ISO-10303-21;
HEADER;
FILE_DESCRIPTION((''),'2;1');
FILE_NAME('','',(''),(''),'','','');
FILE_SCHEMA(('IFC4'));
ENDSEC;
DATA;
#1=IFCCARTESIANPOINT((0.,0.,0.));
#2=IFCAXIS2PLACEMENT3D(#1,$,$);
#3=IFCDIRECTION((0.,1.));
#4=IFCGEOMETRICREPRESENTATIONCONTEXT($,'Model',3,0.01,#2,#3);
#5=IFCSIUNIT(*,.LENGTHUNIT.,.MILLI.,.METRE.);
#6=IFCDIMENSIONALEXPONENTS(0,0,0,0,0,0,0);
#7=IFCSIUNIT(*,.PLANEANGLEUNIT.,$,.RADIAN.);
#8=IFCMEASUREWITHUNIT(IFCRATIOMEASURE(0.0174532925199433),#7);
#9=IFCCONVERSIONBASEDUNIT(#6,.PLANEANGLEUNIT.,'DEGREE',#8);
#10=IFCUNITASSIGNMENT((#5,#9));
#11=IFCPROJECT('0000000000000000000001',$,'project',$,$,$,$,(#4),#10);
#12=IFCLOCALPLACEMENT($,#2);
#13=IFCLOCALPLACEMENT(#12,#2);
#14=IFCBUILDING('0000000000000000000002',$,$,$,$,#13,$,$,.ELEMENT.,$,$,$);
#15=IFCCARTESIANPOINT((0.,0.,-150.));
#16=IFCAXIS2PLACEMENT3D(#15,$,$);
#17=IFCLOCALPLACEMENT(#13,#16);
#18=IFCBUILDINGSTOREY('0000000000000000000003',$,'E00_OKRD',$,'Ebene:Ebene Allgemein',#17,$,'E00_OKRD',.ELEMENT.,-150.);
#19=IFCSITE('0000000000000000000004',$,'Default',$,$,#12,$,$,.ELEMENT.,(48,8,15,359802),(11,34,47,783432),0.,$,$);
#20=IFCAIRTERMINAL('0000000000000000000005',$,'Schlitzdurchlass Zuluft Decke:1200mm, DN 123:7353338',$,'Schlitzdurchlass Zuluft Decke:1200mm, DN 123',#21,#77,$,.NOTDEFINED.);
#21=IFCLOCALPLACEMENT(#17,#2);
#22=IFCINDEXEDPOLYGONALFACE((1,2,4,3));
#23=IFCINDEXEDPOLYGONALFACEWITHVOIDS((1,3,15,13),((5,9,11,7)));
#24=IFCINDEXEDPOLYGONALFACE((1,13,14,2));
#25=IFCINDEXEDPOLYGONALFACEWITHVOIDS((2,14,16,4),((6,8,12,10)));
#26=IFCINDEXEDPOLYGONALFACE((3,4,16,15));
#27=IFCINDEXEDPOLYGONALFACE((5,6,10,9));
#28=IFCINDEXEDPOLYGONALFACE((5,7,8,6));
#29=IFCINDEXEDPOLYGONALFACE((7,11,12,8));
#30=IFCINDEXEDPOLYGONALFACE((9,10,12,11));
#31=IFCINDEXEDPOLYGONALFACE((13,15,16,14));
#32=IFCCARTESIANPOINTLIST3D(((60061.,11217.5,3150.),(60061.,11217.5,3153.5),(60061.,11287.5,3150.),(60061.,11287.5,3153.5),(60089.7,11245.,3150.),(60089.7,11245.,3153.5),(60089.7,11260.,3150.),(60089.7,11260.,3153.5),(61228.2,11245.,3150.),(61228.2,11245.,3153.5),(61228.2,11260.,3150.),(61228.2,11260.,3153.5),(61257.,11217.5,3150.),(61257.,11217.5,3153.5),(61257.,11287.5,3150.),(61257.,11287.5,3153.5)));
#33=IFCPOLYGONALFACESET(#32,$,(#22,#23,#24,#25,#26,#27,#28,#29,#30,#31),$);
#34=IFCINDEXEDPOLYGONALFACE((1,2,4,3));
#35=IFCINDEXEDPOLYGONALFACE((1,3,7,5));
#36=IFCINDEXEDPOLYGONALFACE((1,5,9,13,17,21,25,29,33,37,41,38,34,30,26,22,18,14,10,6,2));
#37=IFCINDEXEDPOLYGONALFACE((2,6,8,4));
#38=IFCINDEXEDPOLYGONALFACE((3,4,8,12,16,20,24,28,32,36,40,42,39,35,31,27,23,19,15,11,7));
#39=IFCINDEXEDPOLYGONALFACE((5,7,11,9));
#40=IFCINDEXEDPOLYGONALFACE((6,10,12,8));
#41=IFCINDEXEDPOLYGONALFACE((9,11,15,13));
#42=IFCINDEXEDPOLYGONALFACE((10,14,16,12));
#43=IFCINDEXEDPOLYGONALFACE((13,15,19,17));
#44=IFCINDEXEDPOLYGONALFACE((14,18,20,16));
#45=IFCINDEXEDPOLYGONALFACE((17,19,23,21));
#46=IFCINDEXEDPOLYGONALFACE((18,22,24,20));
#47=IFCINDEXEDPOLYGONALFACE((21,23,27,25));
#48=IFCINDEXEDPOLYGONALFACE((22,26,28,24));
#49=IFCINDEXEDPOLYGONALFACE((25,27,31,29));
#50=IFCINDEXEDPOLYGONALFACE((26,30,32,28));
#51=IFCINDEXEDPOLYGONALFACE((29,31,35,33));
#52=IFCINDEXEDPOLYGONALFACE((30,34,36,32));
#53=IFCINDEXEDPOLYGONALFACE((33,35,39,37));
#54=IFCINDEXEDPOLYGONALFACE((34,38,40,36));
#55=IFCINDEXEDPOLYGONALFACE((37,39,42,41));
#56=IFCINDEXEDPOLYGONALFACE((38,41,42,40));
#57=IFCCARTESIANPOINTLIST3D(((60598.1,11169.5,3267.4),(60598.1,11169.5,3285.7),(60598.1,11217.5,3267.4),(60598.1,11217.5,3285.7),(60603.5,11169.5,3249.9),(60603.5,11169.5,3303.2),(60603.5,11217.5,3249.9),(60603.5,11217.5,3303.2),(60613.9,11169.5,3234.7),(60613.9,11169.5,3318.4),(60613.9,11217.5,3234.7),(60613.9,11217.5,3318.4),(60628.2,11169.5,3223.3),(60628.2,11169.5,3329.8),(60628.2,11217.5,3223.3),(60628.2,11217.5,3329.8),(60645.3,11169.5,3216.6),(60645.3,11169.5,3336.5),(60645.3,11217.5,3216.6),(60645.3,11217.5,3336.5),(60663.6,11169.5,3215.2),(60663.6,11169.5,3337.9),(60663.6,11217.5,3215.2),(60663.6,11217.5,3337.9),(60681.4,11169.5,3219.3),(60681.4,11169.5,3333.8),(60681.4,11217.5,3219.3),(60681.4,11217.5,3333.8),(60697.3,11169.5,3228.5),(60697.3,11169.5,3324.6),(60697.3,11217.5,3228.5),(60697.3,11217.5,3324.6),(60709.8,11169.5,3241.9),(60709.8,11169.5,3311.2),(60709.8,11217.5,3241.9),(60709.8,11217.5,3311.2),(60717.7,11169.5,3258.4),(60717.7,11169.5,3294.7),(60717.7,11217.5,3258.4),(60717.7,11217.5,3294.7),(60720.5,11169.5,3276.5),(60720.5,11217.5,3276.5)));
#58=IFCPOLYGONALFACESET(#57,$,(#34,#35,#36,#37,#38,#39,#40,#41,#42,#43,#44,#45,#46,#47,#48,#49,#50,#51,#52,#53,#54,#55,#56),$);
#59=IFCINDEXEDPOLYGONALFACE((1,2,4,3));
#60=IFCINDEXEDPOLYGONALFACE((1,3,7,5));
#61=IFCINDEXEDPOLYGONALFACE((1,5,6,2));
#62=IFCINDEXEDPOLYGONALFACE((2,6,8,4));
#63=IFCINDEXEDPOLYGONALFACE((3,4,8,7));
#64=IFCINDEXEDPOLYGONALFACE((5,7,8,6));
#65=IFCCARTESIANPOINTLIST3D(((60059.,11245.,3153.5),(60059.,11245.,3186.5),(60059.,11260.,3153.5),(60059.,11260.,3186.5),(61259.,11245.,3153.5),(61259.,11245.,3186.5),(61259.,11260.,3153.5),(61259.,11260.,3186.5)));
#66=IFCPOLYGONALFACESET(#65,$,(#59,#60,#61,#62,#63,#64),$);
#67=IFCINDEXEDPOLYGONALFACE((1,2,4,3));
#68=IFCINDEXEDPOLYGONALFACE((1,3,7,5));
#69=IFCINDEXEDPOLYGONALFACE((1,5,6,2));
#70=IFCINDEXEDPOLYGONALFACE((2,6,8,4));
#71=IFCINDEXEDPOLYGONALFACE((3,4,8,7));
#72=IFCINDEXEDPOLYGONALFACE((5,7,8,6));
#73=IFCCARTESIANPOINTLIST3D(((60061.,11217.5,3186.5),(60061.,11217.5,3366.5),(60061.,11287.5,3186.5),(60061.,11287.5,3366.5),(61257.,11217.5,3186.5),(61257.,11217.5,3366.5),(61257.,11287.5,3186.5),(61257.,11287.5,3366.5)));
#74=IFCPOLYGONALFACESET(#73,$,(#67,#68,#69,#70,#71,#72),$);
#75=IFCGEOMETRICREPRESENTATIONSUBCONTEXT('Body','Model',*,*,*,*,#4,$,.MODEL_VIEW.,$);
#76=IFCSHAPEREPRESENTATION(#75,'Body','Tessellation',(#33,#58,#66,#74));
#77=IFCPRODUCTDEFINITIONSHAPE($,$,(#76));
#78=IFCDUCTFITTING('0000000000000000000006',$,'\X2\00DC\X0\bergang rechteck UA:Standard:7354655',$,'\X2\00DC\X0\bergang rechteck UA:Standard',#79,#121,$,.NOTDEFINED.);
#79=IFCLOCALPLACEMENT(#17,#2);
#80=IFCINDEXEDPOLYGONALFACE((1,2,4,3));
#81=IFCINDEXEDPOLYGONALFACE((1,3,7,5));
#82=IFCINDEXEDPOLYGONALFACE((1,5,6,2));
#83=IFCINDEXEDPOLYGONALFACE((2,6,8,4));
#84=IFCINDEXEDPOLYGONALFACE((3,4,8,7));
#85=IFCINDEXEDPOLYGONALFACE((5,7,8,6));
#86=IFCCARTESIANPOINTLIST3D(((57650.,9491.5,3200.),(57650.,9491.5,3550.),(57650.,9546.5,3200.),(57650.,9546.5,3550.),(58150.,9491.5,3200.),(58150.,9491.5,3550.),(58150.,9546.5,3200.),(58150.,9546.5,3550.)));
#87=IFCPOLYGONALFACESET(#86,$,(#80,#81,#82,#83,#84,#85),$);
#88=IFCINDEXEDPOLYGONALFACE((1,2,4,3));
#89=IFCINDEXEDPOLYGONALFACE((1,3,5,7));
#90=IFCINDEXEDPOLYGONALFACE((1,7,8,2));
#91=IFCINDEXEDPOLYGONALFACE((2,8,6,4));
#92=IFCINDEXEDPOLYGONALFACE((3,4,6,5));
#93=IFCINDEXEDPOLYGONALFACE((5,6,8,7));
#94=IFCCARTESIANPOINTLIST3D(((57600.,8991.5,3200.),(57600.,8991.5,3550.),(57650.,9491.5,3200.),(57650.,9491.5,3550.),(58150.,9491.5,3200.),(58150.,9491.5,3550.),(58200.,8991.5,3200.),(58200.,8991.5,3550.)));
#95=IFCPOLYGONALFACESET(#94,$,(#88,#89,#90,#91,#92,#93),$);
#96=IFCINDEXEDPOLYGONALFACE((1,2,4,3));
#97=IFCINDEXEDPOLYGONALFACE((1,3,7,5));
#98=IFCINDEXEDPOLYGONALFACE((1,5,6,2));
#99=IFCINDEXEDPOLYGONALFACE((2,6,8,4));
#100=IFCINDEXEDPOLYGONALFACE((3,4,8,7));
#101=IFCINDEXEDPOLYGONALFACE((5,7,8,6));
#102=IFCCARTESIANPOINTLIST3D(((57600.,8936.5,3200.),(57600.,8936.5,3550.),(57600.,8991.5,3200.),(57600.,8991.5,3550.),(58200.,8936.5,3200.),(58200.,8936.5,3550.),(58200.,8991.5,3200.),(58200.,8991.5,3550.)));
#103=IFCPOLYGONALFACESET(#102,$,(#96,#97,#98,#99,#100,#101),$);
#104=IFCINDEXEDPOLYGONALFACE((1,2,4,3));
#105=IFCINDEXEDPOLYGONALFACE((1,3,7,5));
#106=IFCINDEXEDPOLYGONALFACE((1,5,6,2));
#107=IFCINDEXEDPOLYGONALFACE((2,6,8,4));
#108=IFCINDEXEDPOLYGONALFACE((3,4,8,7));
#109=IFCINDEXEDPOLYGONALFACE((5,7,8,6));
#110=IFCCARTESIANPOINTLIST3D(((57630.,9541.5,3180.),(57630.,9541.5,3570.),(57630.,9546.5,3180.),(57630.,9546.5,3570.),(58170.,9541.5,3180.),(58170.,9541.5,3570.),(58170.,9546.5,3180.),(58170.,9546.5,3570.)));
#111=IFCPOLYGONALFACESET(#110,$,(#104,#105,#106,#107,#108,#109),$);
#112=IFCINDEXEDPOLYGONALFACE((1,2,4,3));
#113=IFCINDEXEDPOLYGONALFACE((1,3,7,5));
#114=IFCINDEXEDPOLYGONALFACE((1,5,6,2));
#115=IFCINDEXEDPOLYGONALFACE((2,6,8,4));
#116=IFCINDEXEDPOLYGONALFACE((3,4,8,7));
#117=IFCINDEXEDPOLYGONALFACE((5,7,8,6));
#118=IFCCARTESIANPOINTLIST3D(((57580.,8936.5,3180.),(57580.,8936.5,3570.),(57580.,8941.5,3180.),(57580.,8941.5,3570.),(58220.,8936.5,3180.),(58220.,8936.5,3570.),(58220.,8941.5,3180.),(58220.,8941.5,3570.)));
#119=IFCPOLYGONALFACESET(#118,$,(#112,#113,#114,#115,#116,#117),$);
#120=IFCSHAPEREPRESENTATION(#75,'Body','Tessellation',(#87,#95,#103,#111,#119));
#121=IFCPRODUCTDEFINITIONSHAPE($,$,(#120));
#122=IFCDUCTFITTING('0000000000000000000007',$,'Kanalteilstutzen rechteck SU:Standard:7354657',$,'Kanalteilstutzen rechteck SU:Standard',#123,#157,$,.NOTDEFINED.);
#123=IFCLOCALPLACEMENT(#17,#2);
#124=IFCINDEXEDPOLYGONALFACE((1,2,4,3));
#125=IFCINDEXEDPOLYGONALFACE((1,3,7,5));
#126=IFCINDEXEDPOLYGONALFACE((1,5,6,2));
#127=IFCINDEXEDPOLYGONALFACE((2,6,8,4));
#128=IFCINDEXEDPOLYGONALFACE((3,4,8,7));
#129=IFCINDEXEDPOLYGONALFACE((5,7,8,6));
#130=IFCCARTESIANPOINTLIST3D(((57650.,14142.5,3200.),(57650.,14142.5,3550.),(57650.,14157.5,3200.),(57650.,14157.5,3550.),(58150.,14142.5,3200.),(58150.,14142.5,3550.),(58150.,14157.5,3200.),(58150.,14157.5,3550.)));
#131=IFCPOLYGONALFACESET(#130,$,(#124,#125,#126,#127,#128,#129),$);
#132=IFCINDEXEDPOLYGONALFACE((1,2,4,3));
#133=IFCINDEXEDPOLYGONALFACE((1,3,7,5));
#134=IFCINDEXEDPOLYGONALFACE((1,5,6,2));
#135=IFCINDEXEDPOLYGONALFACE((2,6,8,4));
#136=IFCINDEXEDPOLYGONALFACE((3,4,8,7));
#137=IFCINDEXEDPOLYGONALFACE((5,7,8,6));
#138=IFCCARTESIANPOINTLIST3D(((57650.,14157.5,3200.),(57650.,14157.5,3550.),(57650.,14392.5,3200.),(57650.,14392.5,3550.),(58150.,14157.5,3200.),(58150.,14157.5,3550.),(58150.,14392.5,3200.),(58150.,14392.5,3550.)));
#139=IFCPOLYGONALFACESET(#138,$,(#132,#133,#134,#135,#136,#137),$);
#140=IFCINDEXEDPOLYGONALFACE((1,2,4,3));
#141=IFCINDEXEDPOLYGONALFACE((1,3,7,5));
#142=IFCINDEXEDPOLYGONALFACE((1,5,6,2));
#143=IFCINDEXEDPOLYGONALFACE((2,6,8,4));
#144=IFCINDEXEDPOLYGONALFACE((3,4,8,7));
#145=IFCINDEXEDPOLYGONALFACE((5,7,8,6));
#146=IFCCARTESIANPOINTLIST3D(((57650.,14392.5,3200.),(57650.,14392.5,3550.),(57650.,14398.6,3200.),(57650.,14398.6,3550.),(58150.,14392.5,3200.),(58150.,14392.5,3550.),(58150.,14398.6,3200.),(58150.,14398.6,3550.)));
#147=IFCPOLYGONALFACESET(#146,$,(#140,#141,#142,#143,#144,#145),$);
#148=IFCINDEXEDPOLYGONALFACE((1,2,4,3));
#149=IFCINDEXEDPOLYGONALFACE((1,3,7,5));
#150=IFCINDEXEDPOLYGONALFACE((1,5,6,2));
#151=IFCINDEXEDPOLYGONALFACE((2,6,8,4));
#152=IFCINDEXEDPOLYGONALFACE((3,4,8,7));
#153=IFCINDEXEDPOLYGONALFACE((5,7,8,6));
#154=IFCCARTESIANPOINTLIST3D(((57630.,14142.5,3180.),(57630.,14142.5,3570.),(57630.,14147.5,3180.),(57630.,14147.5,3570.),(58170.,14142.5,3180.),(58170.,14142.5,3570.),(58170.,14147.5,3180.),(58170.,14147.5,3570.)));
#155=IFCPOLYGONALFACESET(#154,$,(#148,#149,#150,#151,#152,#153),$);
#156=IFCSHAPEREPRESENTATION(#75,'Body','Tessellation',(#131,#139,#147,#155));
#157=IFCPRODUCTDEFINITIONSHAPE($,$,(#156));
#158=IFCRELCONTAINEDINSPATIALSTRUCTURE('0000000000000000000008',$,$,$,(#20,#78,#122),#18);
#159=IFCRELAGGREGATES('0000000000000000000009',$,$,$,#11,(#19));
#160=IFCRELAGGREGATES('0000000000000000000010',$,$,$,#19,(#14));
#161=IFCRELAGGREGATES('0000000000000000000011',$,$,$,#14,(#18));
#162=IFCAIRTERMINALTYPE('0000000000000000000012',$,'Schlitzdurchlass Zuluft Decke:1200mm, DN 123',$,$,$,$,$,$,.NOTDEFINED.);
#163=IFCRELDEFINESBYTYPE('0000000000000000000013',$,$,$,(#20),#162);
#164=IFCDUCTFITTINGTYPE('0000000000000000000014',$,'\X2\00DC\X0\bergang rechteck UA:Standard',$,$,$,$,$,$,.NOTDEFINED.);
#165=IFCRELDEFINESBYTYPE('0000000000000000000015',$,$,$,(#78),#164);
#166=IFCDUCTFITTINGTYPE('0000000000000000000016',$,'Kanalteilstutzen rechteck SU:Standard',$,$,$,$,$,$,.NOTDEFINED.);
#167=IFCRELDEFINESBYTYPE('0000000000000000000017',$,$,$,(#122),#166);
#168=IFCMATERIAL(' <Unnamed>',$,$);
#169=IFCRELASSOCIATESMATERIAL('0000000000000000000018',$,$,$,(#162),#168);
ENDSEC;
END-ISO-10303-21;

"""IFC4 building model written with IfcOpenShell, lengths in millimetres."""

from ifc_helpers import new_model, entity, si_unit, converted_unit, direction, frame, frame_2d, origin, origin_2d_with_axis, place, context, subcontext, project, spatial, polyline, rectangle, circle, outline, extrude, source, transform, mapped, material, type_object, type_shapes, element, save


model = new_model("IFC4")

# Units and contexts
model_context = context("Model", 3, precision=0.01, world=origin(), true_north=direction((0.0, 1.0)))
body_context = subcontext(model_context, "Body", "Model", "MODEL_VIEW")
ifc_project = project(units=[si_unit("LENGTHUNIT", "METRE", prefix="MILLI"), converted_unit("PLANEANGLEUNIT", "DEGREE", entity("IfcRatioMeasure", 0.0174532925199433), si_unit("PLANEANGLEUNIT", "RADIAN"), dimensions=[0, 0, 0, 0, 0, 0, 0])], contexts=[model_context])

# Site, building, storey
site_placement = place(None, origin())
site = spatial("IfcSite", under=ifc_project, at=site_placement, Name="Default", CompositionType="ELEMENT", RefLatitude=(48, 8, 15, 359802), RefLongitude=(11, 34, 47, 783432), RefElevation=0.0)
building_placement = place(site_placement, origin())
building = spatial("IfcBuilding", under=site, at=building_placement, CompositionType="ELEMENT")
storey_placement = place(building_placement, frame((0.0, 0.0, -150.0)))
storey = spatial("IfcBuildingStorey", under=building, at=storey_placement, Name="E00_OKRD", ObjectType="Ebene:Ebene Allgemein", LongName="E00_OKRD", CompositionType="ELEMENT", Elevation=-150.0)

# Shared definitions
ifc_material_1 = material(Name=" <Unnamed>")

# Air terminal
air_terminal_type_1 = type_object("IfcAirTerminalType", Name="Schlitzdurchlass Zuluft Decke:1200mm, DN 123", PredefinedType="NOTDEFINED", material=ifc_material_1)
shared_shape_1 = source(origin(), body_context, "Body", "SweptSolid", [
    extrude(outline(polyline([(-598.0, -35.0), (598.0, -35.0), (598.0, 35.0), (-598.0, 35.0), (-598.0, -35.0)]), holes=[polyline([(-569.2, -7.5), (-569.2, 7.5), (569.2, 7.5), (569.2, -7.5), (-569.2, -7.5)])]), frame((600.0, 35.0, 0.0), z_axis=(0.0, 0.0, 1.0), x_axis=(-1.0, 0.0, 0.0)), (0.0, 0.0, 1.0), 3.6),
    extrude(circle(Radius=61.5, at=frame_2d((0.0, 0.0), x_axis=(1.0, 0.0))), frame((600.0, 70.0, 126.6), z_axis=(0.0, 1.0, 0.0), x_axis=(-1.0, 0.0, 0.0)), (0.0, 0.0, 1.0), 48.0),
    extrude(rectangle(XDim=1200.0, YDim=15.0, at=origin_2d_with_axis()), frame((600.0, 35.0, 3.6), z_axis=(0.0, 0.0, 1.0), x_axis=(-1.0, 0.0, 0.0)), (0.0, 0.0, 1.0), 33.0),
    extrude(rectangle(XDim=1196.0, YDim=70.0, at=origin_2d_with_axis()), frame((600.0, 35.0, 36.6), z_axis=(0.0, 0.0, 1.0), x_axis=(-1.0, 0.0, 0.0)), (0.0, 0.0, 1.0), 180.0),
])
type_shapes(air_terminal_type_1, [shared_shape_1])
air_terminal_1_placement = place(storey_placement, frame((61259.0, 11287.5, 3150.0), z_axis=(0.0, 0.0, 1.0), x_axis=(-1.0, 0.0, 0.0)))
element("IfcAirTerminal", 1, at=air_terminal_1_placement, inside=storey, type_object=air_terminal_type_1, Name="Schlitzdurchlass Zuluft Decke:1200mm, DN 123:7353338", ObjectType="Schlitzdurchlass Zuluft Decke:1200mm, DN 123", PredefinedType="NOTDEFINED", context=body_context, shape_type="MappedRepresentation", body=[
    mapped(shared_shape_1, transform((0.0, 0.0, 0.0), scale=1.0)),
])

# Duct fittings
duct_fitting_type_1 = type_object("IfcDuctFittingType", Name="Übergang rechteck UA:Standard", PredefinedType="NOTDEFINED")
shared_shape_2 = source(origin(), body_context, "Body", "SweptSolid", [
    extrude(rectangle(XDim=55.0, YDim=500.0, at=frame_2d((0.0, 0.0), x_axis=(1.0, 0.0))), frame((582.5, 0.0, -175.0)), (0.0, 0.0, 1.0), 350.0),
    extrude(outline(polyline([(-278.6, -273.6), (223.9, -273.6), (273.6, 223.9), (-218.9, 323.4), (-278.6, -273.6)])), frame((305.0, 0.0, -175.0), z_axis=(0.0, 0.0, 1.0), x_axis=(0.995037, 0.099504, 0.0)), (0.0, 0.0, 1.0), 350.0),
    extrude(rectangle(XDim=55.0, YDim=600.0, at=frame_2d((0.0, 0.0), x_axis=(1.0, 0.0))), frame((27.5, 0.0, -175.0)), (0.0, 0.0, 1.0), 350.0),
    extrude(rectangle(XDim=5.0, YDim=540.0, at=frame_2d((0.0, 0.0), x_axis=(1.0, 0.0))), frame((607.5, 0.0, -195.0)), (0.0, 0.0, 1.0), 390.0),
    extrude(rectangle(XDim=5.0, YDim=640.0, at=frame_2d((0.0, 0.0), x_axis=(1.0, 0.0))), frame((2.5, 0.0, -195.0)), (0.0, 0.0, 1.0), 390.0),
])
type_shapes(duct_fitting_type_1, [shared_shape_2])
duct_fitting_1_placement = place(storey_placement, frame((57900.0, 8936.5, 3375.0), z_axis=(0.0, 0.0, 1.0), x_axis=(0.0, 1.0, 0.0)))
element("IfcDuctFitting", 2, at=duct_fitting_1_placement, inside=storey, type_object=duct_fitting_type_1, Name="Übergang rechteck UA:Standard:7354655", ObjectType="Übergang rechteck UA:Standard", PredefinedType="NOTDEFINED", context=body_context, shape_type="MappedRepresentation", body=[
    mapped(shared_shape_2, transform((0.0, 0.0, 0.0), scale=1.0)),
])
duct_fitting_type_2 = type_object("IfcDuctFittingType", Name="Kanalteilstutzen rechteck SU:Standard", PredefinedType="NOTDEFINED")
shared_shape_3 = source(origin(), body_context, "Body", "SweptSolid", [
    extrude(rectangle(XDim=15.0, YDim=350.0, at=frame_2d((0.0, 0.0), x_axis=(1.0, 0.0))), frame((242.5, 0.0, -250.0)), (0.0, 0.0, 1.0), 500.0),
    extrude(rectangle(XDim=235.0, YDim=350.0, at=frame_2d((0.0, 0.0), x_axis=(1.0, 0.0))), frame((117.5, 0.0, -250.0)), (0.0, 0.0, 1.0), 500.0),
    extrude(rectangle(XDim=6.1, YDim=350.0, at=frame_2d((0.0, 0.0), x_axis=(1.0, 0.0))), frame((-3.0, 0.0, -250.0)), (0.0, 0.0, 1.0), 500.0),
    extrude(rectangle(XDim=5.0, YDim=390.0, at=frame_2d((0.0, 0.0), x_axis=(1.0, 0.0))), frame((247.5, 0.0, -270.0)), (0.0, 0.0, 1.0), 540.0),
])
type_shapes(duct_fitting_type_2, [shared_shape_3])
duct_fitting_2_placement = place(storey_placement, frame((57900.0, 14392.5, 3375.0), z_axis=(-1.0, 0.0, 0.0), x_axis=(0.0, -1.0, 0.0)))
element("IfcDuctFitting", 3, at=duct_fitting_2_placement, inside=storey, type_object=duct_fitting_type_2, Name="Kanalteilstutzen rechteck SU:Standard:7354657", ObjectType="Kanalteilstutzen rechteck SU:Standard", PredefinedType="NOTDEFINED", context=body_context, shape_type="MappedRepresentation", body=[
    mapped(shared_shape_3, transform((0.0, 0.0, 0.0), scale=1.0)),
])

save(model, "model.ifc")
